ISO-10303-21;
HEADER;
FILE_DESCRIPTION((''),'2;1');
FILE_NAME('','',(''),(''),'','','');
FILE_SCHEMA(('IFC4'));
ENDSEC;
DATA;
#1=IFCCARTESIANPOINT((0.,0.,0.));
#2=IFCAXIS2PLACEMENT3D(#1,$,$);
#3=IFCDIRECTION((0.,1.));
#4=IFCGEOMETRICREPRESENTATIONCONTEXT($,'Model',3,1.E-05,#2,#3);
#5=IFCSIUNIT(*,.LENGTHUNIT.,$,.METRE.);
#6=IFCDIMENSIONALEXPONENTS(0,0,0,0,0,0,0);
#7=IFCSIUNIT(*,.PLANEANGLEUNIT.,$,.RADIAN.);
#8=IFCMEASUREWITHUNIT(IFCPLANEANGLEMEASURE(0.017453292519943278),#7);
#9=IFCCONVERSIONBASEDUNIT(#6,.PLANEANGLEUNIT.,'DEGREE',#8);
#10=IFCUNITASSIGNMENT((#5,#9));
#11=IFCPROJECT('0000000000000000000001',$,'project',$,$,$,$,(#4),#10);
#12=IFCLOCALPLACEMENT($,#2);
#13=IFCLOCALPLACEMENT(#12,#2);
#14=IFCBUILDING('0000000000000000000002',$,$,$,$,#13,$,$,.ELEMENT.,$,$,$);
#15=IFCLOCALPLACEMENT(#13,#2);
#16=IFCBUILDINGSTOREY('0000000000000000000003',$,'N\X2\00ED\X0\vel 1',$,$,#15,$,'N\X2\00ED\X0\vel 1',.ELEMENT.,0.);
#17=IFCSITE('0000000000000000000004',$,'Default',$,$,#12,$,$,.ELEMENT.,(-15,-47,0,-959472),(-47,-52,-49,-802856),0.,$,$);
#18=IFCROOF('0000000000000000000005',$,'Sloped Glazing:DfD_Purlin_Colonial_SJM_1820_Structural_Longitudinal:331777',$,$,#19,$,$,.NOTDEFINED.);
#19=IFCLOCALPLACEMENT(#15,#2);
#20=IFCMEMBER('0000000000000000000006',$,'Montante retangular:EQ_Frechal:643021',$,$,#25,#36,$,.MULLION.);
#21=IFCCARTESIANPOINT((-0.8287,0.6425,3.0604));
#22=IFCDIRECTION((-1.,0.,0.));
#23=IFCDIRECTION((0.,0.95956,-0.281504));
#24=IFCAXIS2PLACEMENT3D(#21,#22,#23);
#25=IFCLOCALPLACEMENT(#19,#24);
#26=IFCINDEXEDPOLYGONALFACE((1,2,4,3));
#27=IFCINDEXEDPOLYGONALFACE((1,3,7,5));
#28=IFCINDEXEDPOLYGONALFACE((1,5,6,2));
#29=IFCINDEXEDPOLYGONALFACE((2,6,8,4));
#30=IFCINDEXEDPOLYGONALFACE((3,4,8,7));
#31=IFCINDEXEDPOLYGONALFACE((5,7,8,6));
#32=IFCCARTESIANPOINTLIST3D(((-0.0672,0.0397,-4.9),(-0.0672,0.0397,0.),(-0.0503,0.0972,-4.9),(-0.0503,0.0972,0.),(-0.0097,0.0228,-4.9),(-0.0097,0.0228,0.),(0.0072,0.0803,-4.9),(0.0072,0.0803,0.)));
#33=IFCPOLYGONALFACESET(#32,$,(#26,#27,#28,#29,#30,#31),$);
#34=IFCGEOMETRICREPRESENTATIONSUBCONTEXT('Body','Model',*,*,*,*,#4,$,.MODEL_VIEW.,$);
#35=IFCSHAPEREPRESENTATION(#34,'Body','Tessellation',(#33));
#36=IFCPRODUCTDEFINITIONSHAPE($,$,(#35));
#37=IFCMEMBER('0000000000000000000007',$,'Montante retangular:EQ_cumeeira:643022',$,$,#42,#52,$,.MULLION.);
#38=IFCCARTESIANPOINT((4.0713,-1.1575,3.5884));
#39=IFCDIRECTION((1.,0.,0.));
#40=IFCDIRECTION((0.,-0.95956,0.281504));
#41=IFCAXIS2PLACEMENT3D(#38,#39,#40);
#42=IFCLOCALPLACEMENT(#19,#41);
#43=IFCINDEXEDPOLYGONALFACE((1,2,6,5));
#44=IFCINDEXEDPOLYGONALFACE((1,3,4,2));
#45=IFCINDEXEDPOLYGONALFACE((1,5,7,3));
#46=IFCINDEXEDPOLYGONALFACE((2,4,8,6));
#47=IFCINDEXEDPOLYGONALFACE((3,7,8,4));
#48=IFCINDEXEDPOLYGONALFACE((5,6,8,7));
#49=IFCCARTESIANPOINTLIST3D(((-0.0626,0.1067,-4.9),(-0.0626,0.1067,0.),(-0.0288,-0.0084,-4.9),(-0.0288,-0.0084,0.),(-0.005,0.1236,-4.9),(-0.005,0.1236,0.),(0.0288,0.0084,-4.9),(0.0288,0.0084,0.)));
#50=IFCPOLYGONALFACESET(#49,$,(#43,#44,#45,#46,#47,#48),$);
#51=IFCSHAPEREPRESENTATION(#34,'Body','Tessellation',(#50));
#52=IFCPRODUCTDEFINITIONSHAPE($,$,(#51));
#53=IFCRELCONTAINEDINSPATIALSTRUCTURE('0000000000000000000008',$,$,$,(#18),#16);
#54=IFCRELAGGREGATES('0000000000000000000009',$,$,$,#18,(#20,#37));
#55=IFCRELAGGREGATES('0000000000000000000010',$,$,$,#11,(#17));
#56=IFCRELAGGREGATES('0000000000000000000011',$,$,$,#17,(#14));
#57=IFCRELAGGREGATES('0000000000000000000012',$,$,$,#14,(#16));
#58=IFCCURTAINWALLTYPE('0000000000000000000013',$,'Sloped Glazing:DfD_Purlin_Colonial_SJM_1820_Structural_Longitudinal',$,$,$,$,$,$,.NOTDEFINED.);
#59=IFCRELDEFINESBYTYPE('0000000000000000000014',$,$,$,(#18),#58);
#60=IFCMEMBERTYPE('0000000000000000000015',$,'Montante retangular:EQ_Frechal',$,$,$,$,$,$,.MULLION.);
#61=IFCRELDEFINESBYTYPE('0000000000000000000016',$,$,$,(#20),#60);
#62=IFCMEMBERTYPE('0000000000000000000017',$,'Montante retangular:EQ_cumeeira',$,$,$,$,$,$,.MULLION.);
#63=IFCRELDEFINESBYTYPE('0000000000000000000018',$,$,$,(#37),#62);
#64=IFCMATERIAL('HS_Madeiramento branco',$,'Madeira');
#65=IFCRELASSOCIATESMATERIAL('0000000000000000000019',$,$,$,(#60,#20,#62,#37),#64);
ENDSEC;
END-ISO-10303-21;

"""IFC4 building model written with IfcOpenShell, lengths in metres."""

from ifc_helpers import new_model, entity, si_unit, converted_unit, direction, frame, origin, place, context, subcontext, project, spatial, indexed_curve, outline, extrude, source, transform, mapped, material, type_object, type_shapes, element, aggregate, save


model = new_model("IFC4")

# Units and contexts
model_context = context("Model", 3, precision=1e-05, world=origin(), true_north=direction((0.0, 1.0)))
body_context = subcontext(model_context, "Body", "Model", "MODEL_VIEW")
ifc_project = project(units=[si_unit("LENGTHUNIT", "METRE"), converted_unit("PLANEANGLEUNIT", "DEGREE", entity("IfcPlaneAngleMeasure", 0.017453292519943278), si_unit("PLANEANGLEUNIT", "RADIAN"), dimensions=[0, 0, 0, 0, 0, 0, 0])], contexts=[model_context])

# Site, building, storey
site_placement = place(None, origin())
site = spatial("IfcSite", under=ifc_project, at=site_placement, Name="Default", CompositionType="ELEMENT", RefLatitude=(-15, -47, 0, -959472), RefLongitude=(-47, -52, -49, -802856), RefElevation=0.0)
building_placement = place(site_placement, origin())
building = spatial("IfcBuilding", under=site, at=building_placement, CompositionType="ELEMENT")
storey_placement = place(building_placement, origin())
storey = spatial("IfcBuildingStorey", under=building, at=storey_placement, Name="Nível 1", LongName="Nível 1", CompositionType="ELEMENT", Elevation=0.0)

# Roof, members
curtain_wall_type = type_object("IfcCurtainWallType", Name="Sloped Glazing:DfD_Purlin_Colonial_SJM_1820_Structural_Longitudinal", PredefinedType="NOTDEFINED")
roof_placement = place(storey_placement, origin())
roof = element("IfcRoof", 1, at=roof_placement, inside=storey, type_object=curtain_wall_type, Name="Sloped Glazing:DfD_Purlin_Colonial_SJM_1820_Structural_Longitudinal:331777", PredefinedType="NOTDEFINED")
ifc_material_1 = material(Name="HS_Madeiramento branco", Category="Madeira")
member_type_1 = type_object("IfcMemberType", Name="Montante retangular:EQ_Frechal", PredefinedType="MULLION", material=ifc_material_1)
shared_shape_1 = source(origin(), body_context, "Body", "SweptSolid", [
    extrude(outline(indexed_curve([(-0.03, -0.03), (0.03, -0.03), (0.03, 0.03), (-0.03, 0.03), (-0.03, -0.03)], self_intersect=False)), frame((-0.03, 0.06, -4.9), z_axis=(0.0, 0.0, 1.0), x_axis=(0.95956, -0.281504, 0.0)), (0.0, 0.0, 1.0), 4.9),
])
type_shapes(member_type_1, [shared_shape_1])
member_1_placement = place(roof_placement, frame((-0.8287, 0.6425, 3.0604), z_axis=(-1.0, 0.0, 0.0), x_axis=(0.0, 0.95956, -0.281504)))
member_1 = element("IfcMember", 2, at=member_1_placement, type_object=member_type_1, material=ifc_material_1, Name="Montante retangular:EQ_Frechal:643021", PredefinedType="MULLION", context=body_context, shape_type="MappedRepresentation", body=[
    mapped(shared_shape_1, transform((0.0, 0.0, 0.0), scale=1.0)),
])
member_type_2 = type_object("IfcMemberType", Name="Montante retangular:EQ_cumeeira", PredefinedType="MULLION", material=ifc_material_1)
shared_shape_2 = source(origin(), body_context, "Body", "SweptSolid", [
    extrude(outline(indexed_curve([(-0.06, -0.03), (0.06, -0.03), (0.06, 0.03), (-0.06, 0.03), (-0.06, -0.03)], self_intersect=False)), frame((-0.0169, 0.0576, -4.9), z_axis=(0.0, 0.0, 1.0), x_axis=(-0.281504, 0.95956, 0.0)), (0.0, 0.0, 1.0), 4.9),
])
type_shapes(member_type_2, [shared_shape_2])
member_2_placement = place(roof_placement, frame((4.0713, -1.1575, 3.5884), z_axis=(1.0, 0.0, 0.0), x_axis=(0.0, -0.95956, 0.281504)))
member_2 = element("IfcMember", 3, at=member_2_placement, type_object=member_type_2, material=ifc_material_1, Name="Montante retangular:EQ_cumeeira:643022", PredefinedType="MULLION", context=body_context, shape_type="MappedRepresentation", body=[
    mapped(shared_shape_2, transform((0.0, 0.0, 0.0), scale=1.0)),
])
aggregate(roof, [member_1, member_2])

save(model, "model.ifc")
